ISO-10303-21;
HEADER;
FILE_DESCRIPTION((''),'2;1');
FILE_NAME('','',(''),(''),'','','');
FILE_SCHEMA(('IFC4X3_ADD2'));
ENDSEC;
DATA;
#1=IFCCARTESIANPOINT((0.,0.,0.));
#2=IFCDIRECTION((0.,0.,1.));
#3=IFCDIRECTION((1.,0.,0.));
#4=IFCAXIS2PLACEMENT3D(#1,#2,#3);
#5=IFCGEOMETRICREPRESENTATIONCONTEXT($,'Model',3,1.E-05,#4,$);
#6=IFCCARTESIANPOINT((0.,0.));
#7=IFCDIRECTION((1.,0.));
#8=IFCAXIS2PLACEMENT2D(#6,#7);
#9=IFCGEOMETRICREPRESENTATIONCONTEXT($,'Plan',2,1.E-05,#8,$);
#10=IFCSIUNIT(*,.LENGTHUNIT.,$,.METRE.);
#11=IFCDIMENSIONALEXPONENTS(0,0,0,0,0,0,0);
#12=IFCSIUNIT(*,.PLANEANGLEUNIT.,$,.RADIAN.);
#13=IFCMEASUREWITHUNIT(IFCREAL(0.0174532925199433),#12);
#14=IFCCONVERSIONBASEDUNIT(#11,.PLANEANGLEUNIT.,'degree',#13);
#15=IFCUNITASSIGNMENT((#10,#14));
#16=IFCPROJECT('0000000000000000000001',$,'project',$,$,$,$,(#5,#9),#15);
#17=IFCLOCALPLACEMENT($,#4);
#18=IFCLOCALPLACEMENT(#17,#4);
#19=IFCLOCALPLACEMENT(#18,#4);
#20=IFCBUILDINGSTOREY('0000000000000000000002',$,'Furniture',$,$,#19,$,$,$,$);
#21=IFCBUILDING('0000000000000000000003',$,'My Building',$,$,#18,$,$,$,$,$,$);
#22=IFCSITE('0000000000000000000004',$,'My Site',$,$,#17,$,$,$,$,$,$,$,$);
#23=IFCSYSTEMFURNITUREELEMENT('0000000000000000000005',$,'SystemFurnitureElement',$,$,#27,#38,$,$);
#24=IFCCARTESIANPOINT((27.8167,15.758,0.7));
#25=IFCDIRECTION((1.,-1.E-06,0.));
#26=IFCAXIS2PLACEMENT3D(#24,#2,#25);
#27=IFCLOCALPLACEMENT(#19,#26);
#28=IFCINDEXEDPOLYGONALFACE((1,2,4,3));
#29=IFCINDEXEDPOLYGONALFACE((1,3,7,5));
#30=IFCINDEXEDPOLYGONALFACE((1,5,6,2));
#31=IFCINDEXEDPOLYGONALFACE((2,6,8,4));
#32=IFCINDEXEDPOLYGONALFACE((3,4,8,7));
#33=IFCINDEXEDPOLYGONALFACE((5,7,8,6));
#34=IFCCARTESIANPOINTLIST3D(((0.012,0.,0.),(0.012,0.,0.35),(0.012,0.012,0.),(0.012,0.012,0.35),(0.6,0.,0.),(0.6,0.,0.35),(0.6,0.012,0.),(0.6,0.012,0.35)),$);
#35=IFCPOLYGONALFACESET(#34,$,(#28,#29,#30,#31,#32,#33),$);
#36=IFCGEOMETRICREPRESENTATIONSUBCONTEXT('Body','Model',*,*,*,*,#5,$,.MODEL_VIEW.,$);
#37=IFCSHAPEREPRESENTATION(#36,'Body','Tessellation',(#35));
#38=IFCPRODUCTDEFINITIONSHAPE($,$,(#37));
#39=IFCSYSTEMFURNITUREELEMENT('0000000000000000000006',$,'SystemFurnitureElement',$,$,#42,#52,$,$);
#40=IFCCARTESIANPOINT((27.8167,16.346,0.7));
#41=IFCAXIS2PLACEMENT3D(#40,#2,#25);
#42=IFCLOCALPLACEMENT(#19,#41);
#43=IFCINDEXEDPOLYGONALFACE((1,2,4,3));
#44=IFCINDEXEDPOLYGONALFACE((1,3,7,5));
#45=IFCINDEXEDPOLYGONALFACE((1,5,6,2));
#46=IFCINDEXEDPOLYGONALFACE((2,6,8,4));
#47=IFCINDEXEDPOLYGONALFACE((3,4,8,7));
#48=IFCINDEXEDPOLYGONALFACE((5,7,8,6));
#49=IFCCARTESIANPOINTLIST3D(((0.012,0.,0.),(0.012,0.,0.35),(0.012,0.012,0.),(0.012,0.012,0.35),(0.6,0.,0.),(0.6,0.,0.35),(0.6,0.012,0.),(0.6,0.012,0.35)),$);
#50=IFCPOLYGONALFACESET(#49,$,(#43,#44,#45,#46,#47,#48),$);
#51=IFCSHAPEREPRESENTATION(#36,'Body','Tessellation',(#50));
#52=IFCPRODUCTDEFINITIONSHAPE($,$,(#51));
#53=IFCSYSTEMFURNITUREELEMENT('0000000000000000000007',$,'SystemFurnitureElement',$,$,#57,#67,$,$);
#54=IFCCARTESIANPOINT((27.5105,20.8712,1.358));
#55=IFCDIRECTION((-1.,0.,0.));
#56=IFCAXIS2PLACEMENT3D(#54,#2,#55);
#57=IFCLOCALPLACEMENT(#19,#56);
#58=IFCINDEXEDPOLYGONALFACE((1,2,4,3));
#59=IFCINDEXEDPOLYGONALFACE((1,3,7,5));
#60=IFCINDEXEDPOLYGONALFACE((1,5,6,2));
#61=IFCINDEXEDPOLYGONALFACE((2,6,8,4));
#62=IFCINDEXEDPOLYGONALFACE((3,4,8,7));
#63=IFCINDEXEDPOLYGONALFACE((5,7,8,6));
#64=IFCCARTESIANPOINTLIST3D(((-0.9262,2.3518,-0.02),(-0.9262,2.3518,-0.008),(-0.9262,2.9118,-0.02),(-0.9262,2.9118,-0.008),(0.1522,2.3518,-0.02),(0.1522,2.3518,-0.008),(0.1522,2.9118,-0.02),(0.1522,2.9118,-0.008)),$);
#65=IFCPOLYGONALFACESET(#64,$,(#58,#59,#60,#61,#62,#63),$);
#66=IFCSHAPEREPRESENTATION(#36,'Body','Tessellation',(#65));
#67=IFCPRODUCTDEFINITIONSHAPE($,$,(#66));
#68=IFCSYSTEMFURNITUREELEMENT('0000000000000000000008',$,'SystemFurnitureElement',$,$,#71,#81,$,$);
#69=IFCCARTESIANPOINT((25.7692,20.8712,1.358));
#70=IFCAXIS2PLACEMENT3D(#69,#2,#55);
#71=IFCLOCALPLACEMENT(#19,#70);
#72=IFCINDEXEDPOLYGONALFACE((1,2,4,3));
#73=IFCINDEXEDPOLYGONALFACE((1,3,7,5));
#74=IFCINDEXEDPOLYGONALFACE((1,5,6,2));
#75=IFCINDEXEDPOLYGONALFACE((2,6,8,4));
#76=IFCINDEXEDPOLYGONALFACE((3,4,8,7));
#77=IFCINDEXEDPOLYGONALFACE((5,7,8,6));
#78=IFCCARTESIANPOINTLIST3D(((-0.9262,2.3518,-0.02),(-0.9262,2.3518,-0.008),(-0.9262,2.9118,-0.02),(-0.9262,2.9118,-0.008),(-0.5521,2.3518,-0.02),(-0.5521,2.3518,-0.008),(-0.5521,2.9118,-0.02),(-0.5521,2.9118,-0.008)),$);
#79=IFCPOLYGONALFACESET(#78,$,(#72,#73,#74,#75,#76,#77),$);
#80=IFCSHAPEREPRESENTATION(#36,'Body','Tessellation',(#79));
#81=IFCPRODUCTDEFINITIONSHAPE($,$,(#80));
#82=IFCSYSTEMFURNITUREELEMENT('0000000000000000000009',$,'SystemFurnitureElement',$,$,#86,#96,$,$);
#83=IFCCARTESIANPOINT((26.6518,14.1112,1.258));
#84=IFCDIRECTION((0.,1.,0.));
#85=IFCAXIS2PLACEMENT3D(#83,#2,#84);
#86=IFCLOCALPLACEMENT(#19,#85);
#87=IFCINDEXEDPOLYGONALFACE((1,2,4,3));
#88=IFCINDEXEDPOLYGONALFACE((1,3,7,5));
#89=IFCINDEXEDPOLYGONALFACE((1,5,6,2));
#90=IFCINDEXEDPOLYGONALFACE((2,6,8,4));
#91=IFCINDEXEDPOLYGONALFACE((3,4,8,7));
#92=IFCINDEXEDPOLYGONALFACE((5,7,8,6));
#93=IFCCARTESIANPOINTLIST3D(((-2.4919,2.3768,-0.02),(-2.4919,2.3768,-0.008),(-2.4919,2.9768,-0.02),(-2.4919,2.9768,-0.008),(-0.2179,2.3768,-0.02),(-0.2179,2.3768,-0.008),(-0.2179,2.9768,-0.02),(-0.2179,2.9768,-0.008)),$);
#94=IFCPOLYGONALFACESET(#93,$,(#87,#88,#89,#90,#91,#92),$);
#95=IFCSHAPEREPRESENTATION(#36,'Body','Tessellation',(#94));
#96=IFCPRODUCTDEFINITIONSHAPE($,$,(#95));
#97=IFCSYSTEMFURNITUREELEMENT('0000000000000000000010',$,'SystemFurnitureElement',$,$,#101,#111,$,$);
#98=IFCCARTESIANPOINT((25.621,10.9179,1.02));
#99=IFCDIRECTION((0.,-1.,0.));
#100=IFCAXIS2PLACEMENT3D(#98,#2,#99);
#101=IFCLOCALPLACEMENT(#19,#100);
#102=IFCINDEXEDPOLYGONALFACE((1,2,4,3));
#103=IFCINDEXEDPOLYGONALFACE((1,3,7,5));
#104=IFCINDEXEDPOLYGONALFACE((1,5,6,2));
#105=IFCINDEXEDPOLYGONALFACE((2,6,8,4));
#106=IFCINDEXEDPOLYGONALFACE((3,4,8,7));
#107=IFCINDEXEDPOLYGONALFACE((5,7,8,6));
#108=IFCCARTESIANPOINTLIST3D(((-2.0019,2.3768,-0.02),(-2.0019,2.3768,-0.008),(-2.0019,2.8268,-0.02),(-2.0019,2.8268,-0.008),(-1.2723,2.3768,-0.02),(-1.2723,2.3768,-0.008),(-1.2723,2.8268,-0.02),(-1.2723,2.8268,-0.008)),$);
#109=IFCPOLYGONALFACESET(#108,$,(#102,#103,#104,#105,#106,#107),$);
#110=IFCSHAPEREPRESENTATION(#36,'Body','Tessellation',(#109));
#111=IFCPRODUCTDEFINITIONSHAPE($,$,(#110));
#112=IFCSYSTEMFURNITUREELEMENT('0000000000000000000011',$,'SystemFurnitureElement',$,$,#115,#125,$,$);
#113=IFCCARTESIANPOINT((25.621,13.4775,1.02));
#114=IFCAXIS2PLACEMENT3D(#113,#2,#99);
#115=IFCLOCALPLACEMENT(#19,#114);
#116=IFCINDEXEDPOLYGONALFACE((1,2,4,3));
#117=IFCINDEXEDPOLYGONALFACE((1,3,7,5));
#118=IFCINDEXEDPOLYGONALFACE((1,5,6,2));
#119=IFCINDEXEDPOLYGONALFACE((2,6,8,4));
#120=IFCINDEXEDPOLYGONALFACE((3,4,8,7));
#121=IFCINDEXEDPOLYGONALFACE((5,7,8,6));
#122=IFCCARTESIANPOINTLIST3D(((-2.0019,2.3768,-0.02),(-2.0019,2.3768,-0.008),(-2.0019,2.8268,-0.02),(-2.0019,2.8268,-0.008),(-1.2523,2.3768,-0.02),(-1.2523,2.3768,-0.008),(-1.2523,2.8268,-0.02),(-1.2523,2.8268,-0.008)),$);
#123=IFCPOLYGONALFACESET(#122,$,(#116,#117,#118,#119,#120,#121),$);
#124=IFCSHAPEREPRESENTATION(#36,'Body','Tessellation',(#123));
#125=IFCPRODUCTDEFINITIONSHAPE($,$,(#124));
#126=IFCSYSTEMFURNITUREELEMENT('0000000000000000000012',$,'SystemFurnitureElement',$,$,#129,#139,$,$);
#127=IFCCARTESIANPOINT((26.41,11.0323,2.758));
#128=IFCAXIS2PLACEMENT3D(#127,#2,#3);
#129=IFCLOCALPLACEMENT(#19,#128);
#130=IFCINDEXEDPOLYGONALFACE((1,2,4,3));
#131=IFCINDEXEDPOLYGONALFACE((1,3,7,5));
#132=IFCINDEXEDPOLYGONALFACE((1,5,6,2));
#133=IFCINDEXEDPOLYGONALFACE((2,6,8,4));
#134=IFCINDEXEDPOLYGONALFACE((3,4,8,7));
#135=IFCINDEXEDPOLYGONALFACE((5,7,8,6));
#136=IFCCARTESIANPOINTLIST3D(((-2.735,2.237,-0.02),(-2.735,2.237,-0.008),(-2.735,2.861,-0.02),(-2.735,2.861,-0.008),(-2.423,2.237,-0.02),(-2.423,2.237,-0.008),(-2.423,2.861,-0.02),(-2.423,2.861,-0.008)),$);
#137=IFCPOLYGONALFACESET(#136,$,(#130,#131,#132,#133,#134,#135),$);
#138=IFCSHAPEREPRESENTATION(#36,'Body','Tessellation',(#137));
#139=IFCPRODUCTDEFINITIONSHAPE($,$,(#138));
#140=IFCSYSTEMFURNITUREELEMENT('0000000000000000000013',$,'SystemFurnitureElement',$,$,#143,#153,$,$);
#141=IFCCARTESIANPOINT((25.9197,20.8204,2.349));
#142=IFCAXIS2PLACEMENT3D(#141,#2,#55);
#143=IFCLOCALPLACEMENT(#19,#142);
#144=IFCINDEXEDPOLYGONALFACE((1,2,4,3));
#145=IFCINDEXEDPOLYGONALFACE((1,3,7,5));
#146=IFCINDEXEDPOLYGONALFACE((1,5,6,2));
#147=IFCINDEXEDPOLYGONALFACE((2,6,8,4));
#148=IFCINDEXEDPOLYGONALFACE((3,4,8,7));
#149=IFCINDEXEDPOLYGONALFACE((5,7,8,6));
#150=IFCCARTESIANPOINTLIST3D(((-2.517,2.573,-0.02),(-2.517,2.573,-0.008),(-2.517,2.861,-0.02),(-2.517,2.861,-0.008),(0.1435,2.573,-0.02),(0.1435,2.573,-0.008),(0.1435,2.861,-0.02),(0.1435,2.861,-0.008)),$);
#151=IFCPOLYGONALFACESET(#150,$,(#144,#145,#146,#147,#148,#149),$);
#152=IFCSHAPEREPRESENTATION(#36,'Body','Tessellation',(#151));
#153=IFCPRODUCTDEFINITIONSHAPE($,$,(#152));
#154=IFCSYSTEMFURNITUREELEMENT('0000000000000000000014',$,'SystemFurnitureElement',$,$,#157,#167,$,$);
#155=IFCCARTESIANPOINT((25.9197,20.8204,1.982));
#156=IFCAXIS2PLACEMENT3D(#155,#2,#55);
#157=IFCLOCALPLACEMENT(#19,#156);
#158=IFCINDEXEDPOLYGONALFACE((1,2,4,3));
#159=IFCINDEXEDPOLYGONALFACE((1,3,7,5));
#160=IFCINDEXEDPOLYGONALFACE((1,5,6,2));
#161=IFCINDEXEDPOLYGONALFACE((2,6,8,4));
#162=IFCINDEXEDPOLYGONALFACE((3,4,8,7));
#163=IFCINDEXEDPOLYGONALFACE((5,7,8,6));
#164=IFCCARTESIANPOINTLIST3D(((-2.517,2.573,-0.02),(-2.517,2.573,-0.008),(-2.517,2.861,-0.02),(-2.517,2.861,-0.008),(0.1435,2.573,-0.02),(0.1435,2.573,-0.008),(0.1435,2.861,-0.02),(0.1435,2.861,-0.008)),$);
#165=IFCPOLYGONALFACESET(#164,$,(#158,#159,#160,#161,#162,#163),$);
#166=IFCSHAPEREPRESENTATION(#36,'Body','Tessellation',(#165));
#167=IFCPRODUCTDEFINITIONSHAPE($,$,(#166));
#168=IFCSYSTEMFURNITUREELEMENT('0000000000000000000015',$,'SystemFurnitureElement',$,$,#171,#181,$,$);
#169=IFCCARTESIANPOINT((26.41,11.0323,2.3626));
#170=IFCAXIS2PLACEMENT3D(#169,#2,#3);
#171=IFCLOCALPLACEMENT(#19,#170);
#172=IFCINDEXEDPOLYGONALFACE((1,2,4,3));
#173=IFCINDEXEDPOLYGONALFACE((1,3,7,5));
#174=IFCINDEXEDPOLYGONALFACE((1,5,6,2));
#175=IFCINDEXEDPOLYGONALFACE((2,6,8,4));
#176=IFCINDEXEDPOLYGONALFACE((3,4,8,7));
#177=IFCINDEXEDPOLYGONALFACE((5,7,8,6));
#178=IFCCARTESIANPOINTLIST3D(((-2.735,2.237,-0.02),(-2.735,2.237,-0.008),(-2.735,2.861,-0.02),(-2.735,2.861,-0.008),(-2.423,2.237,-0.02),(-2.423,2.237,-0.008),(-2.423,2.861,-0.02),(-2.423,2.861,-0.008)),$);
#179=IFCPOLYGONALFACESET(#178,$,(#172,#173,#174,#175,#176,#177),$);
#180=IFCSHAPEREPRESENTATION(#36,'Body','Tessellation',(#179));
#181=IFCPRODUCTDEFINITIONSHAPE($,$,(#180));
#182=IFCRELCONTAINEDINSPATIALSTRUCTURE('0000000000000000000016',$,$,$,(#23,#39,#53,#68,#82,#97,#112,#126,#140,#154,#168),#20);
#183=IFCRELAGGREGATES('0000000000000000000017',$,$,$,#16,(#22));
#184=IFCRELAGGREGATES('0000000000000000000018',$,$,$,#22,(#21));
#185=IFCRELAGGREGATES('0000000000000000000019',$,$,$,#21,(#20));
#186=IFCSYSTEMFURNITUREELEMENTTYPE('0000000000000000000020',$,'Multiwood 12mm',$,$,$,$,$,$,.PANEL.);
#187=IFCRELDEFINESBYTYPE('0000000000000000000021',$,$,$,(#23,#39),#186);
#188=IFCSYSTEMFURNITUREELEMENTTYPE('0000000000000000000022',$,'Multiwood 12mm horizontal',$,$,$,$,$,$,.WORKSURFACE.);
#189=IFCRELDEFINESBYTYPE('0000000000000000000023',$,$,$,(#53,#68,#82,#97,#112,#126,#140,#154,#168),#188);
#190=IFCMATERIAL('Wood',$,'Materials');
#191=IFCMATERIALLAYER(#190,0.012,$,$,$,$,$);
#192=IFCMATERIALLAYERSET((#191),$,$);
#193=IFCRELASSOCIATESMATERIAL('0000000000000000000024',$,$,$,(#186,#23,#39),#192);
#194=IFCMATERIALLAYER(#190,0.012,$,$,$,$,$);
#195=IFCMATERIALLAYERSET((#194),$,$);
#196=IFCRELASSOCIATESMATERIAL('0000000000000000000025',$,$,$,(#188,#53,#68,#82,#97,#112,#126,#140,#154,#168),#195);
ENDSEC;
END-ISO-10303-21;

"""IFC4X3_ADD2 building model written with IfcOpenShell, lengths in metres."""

from ifc_helpers import new_model, entity, si_unit, converted_unit, frame, origin_with_axes, origin_2d_with_axis, place, context, subcontext, project, spatial, line, indexed_curve, outline, extrude, material, layer, layer_set, layer_usage, type_object, element, save


model = new_model("IFC4X3_ADD2")

# Units and contexts
model_context = context("Model", 3, precision=1e-05, world=origin_with_axes())
plan_context = context("Plan", 2, precision=1e-05, world=origin_2d_with_axis())
body_context = subcontext(model_context, "Body", "Model", "MODEL_VIEW")
ifc_project = project(units=[si_unit("LENGTHUNIT", "METRE"), converted_unit("PLANEANGLEUNIT", "degree", entity("IfcReal", 0.0174532925199433), si_unit("PLANEANGLEUNIT", "RADIAN"), dimensions=[0, 0, 0, 0, 0, 0, 0])], contexts=[model_context, plan_context])

# Site, building, storey
site_placement = place(None, origin_with_axes())
site = spatial("IfcSite", under=ifc_project, at=site_placement, Name="My Site")
building_placement = place(site_placement, origin_with_axes())
building = spatial("IfcBuilding", under=site, at=building_placement, Name="My Building")
storey_placement = place(building_placement, origin_with_axes())
storey = spatial("IfcBuildingStorey", under=building, at=storey_placement, Name="Furniture")

# System furniture elements
ifc_material_1 = material(Name="Wood", Category="Materials")
ifc_layer_1 = layer(ifc_material_1, 0.012)
ifc_layer_set_1 = layer_set([ifc_layer_1])
system_furniture_element_type_1 = type_object("IfcSystemFurnitureElementType", Name="Multiwood 12mm", PredefinedType="PANEL", material=ifc_layer_set_1)
ifc_layer_usage_1 = layer_usage(ifc_layer_set_1, "AXIS2", "POSITIVE", 0.0)
system_furniture_element_1_placement = place(storey_placement, frame((27.8167, 15.758, 0.7), z_axis=(0.0, 0.0, 1.0), x_axis=(1.0, -0.000001, 0.0)))
element("IfcSystemFurnitureElement", 1, at=system_furniture_element_1_placement, inside=storey, type_object=system_furniture_element_type_1, material=ifc_layer_usage_1, Name="SystemFurnitureElement", context=body_context, shape_type="SweptSolid", body=[
    extrude(outline(indexed_curve([(0.012, 0.0), (0.012, 0.012), (0.6, 0.012), (0.6, 0.0)], segments=[line(1, 2, 3, 4, 1)])), origin_with_axes(), (0.0, 0.0, 1.0), 0.35),
])
ifc_layer_usage_2 = layer_usage(ifc_layer_set_1, "AXIS2", "POSITIVE", 0.0)
system_furniture_element_2_placement = place(storey_placement, frame((27.8167, 16.346, 0.7), z_axis=(0.0, 0.0, 1.0), x_axis=(1.0, -0.000001, 0.0)))
element("IfcSystemFurnitureElement", 2, at=system_furniture_element_2_placement, inside=storey, type_object=system_furniture_element_type_1, material=ifc_layer_usage_2, Name="SystemFurnitureElement", context=body_context, shape_type="SweptSolid", body=[
    extrude(outline(indexed_curve([(0.012, 0.0), (0.012, 0.012), (0.6, 0.012), (0.6, 0.0)], segments=[line(1, 2, 3, 4, 1)])), origin_with_axes(), (0.0, 0.0, 1.0), 0.35),
])
ifc_layer_2 = layer(ifc_material_1, 0.012)
ifc_layer_set_2 = layer_set([ifc_layer_2])
ifc_layer_usage_3 = layer_usage(ifc_layer_set_2, "AXIS3", "POSITIVE", -0.02)
system_furniture_element_type_2 = type_object("IfcSystemFurnitureElementType", Name="Multiwood 12mm horizontal", PredefinedType="WORKSURFACE", material=ifc_layer_set_2)
system_furniture_element_3_placement = place(storey_placement, frame((27.5105, 20.8712, 1.358), z_axis=(0.0, 0.0, 1.0), x_axis=(-1.0, 0.0, 0.0)))
element("IfcSystemFurnitureElement", 3, at=system_furniture_element_3_placement, inside=storey, type_object=system_furniture_element_type_2, material=ifc_layer_usage_3, Name="SystemFurnitureElement", context=body_context, shape_type="SweptSolid", body=[
    extrude(outline(indexed_curve([(-0.9262, 2.3518), (0.1522, 2.3518), (0.1522, 2.9118), (-0.9262, 2.9118), (-0.9262, 2.3518)])), frame((0.0, 0.0, -0.02), z_axis=(0.0, 0.0, 1.0), x_axis=(1.0, 0.0, 0.0)), (0.0, 0.0, 1.0), 0.012),
])
ifc_layer_usage_4 = layer_usage(ifc_layer_set_2, "AXIS3", "POSITIVE", -0.02)
system_furniture_element_4_placement = place(storey_placement, frame((25.7692, 20.8712, 1.358), z_axis=(0.0, 0.0, 1.0), x_axis=(-1.0, 0.0, 0.0)))
element("IfcSystemFurnitureElement", 4, at=system_furniture_element_4_placement, inside=storey, type_object=system_furniture_element_type_2, material=ifc_layer_usage_4, Name="SystemFurnitureElement", context=body_context, shape_type="SweptSolid", body=[
    extrude(outline(indexed_curve([(-0.9262, 2.3518), (-0.5521, 2.3518), (-0.5521, 2.9118), (-0.9262, 2.9118), (-0.9262, 2.3518)])), frame((0.0, 0.0, -0.02), z_axis=(0.0, 0.0, 1.0), x_axis=(1.0, 0.0, 0.0)), (0.0, 0.0, 1.0), 0.012),
])
ifc_layer_usage_5 = layer_usage(ifc_layer_set_2, "AXIS3", "POSITIVE", -0.02)
system_furniture_element_5_placement = place(storey_placement, frame((26.6518, 14.1112, 1.258), z_axis=(0.0, 0.0, 1.0), x_axis=(0.0, 1.0, 0.0)))
element("IfcSystemFurnitureElement", 5, at=system_furniture_element_5_placement, inside=storey, type_object=system_furniture_element_type_2, material=ifc_layer_usage_5, Name="SystemFurnitureElement", context=body_context, shape_type="SweptSolid", body=[
    extrude(outline(indexed_curve([(-2.4919, 2.9768), (-2.4919, 2.3768), (-0.2179, 2.3768), (-0.2179, 2.9768), (-2.4919, 2.9768)])), frame((0.0, 0.0, -0.02), z_axis=(0.0, 0.0, 1.0), x_axis=(1.0, 0.0, 0.0)), (0.0, 0.0, 1.0), 0.012),
])
ifc_layer_usage_6 = layer_usage(ifc_layer_set_2, "AXIS3", "POSITIVE", -0.02)
system_furniture_element_6_placement = place(storey_placement, frame((25.621, 10.9179, 1.02), z_axis=(0.0, 0.0, 1.0), x_axis=(0.0, -1.0, 0.0)))
element("IfcSystemFurnitureElement", 6, at=system_furniture_element_6_placement, inside=storey, type_object=system_furniture_element_type_2, material=ifc_layer_usage_6, Name="SystemFurnitureElement", context=body_context, shape_type="SweptSolid", body=[
    extrude(outline(indexed_curve([(-1.2723, 2.8268), (-1.2723, 2.3768), (-2.0019, 2.3768), (-2.0019, 2.8268), (-1.2723, 2.8268)])), frame((0.0, 0.0, -0.02), z_axis=(0.0, 0.0, 1.0), x_axis=(1.0, 0.0, 0.0)), (0.0, 0.0, 1.0), 0.012),
])
ifc_layer_usage_7 = layer_usage(ifc_layer_set_2, "AXIS3", "POSITIVE", -0.02)
system_furniture_element_7_placement = place(storey_placement, frame((25.621, 13.4775, 1.02), z_axis=(0.0, 0.0, 1.0), x_axis=(0.0, -1.0, 0.0)))
element("IfcSystemFurnitureElement", 7, at=system_furniture_element_7_placement, inside=storey, type_object=system_furniture_element_type_2, material=ifc_layer_usage_7, Name="SystemFurnitureElement", context=body_context, shape_type="SweptSolid", body=[
    extrude(outline(indexed_curve([(-2.0019, 2.8268), (-2.0019, 2.3768), (-1.2523, 2.3768), (-1.2523, 2.8268), (-2.0019, 2.8268)])), frame((0.0, 0.0, -0.02), z_axis=(0.0, 0.0, 1.0), x_axis=(1.0, 0.0, 0.0)), (0.0, 0.0, 1.0), 0.012),
])
ifc_layer_usage_8 = layer_usage(ifc_layer_set_2, "AXIS3", "POSITIVE", -0.02)
system_furniture_element_8_placement = place(storey_placement, frame((26.41, 11.0323, 2.758), z_axis=(0.0, 0.0, 1.0), x_axis=(1.0, 0.0, 0.0)))
element("IfcSystemFurnitureElement", 8, at=system_furniture_element_8_placement, inside=storey, type_object=system_furniture_element_type_2, material=ifc_layer_usage_8, Name="SystemFurnitureElement", context=body_context, shape_type="SweptSolid", body=[
    extrude(outline(indexed_curve([(-2.423, 2.861), (-2.423, 2.237), (-2.735, 2.237), (-2.735, 2.861), (-2.423, 2.861)])), frame((0.0, 0.0, -0.02), z_axis=(0.0, 0.0, 1.0), x_axis=(1.0, 0.0, 0.0)), (0.0, 0.0, 1.0), 0.012),
])
ifc_layer_usage_9 = layer_usage(ifc_layer_set_2, "AXIS3", "POSITIVE", -0.02)
system_furniture_element_9_placement = place(storey_placement, frame((25.9197, 20.8204, 2.349), z_axis=(0.0, 0.0, 1.0), x_axis=(-1.0, 0.0, 0.0)))
element("IfcSystemFurnitureElement", 9, at=system_furniture_element_9_placement, inside=storey, type_object=system_furniture_element_type_2, material=ifc_layer_usage_9, Name="SystemFurnitureElement", context=body_context, shape_type="SweptSolid", body=[
    extrude(outline(indexed_curve([(-2.517, 2.861), (-2.517, 2.573), (0.1435, 2.573), (0.1435, 2.861), (-2.517, 2.861)])), frame((0.0, 0.0, -0.02), z_axis=(0.0, 0.0, 1.0), x_axis=(1.0, 0.0, 0.0)), (0.0, 0.0, 1.0), 0.012),
])
ifc_layer_usage_10 = layer_usage(ifc_layer_set_2, "AXIS3", "POSITIVE", -0.02)
system_furniture_element_10_placement = place(storey_placement, frame((25.9197, 20.8204, 1.982), z_axis=(0.0, 0.0, 1.0), x_axis=(-1.0, 0.0, 0.0)))
element("IfcSystemFurnitureElement", 10, at=system_furniture_element_10_placement, inside=storey, type_object=system_furniture_element_type_2, material=ifc_layer_usage_10, Name="SystemFurnitureElement", context=body_context, shape_type="SweptSolid", body=[
    extrude(outline(indexed_curve([(-2.517, 2.861), (-2.517, 2.573), (0.1435, 2.573), (0.1435, 2.861), (-2.517, 2.861)])), frame((0.0, 0.0, -0.02), z_axis=(0.0, 0.0, 1.0), x_axis=(1.0, 0.0, 0.0)), (0.0, 0.0, 1.0), 0.012),
])
ifc_layer_usage_11 = layer_usage(ifc_layer_set_2, "AXIS3", "POSITIVE", -0.02)
system_furniture_element_11_placement = place(storey_placement, frame((26.41, 11.0323, 2.3626), z_axis=(0.0, 0.0, 1.0), x_axis=(1.0, 0.0, 0.0)))
element("IfcSystemFurnitureElement", 11, at=system_furniture_element_11_placement, inside=storey, type_object=system_furniture_element_type_2, material=ifc_layer_usage_11, Name="SystemFurnitureElement", context=body_context, shape_type="SweptSolid", body=[
    extrude(outline(indexed_curve([(-2.423, 2.861), (-2.423, 2.237), (-2.735, 2.237), (-2.735, 2.861), (-2.423, 2.861)])), frame((0.0, 0.0, -0.02), z_axis=(0.0, 0.0, 1.0), x_axis=(1.0, 0.0, 0.0)), (0.0, 0.0, 1.0), 0.012),
])

save(model, "model.ifc")
